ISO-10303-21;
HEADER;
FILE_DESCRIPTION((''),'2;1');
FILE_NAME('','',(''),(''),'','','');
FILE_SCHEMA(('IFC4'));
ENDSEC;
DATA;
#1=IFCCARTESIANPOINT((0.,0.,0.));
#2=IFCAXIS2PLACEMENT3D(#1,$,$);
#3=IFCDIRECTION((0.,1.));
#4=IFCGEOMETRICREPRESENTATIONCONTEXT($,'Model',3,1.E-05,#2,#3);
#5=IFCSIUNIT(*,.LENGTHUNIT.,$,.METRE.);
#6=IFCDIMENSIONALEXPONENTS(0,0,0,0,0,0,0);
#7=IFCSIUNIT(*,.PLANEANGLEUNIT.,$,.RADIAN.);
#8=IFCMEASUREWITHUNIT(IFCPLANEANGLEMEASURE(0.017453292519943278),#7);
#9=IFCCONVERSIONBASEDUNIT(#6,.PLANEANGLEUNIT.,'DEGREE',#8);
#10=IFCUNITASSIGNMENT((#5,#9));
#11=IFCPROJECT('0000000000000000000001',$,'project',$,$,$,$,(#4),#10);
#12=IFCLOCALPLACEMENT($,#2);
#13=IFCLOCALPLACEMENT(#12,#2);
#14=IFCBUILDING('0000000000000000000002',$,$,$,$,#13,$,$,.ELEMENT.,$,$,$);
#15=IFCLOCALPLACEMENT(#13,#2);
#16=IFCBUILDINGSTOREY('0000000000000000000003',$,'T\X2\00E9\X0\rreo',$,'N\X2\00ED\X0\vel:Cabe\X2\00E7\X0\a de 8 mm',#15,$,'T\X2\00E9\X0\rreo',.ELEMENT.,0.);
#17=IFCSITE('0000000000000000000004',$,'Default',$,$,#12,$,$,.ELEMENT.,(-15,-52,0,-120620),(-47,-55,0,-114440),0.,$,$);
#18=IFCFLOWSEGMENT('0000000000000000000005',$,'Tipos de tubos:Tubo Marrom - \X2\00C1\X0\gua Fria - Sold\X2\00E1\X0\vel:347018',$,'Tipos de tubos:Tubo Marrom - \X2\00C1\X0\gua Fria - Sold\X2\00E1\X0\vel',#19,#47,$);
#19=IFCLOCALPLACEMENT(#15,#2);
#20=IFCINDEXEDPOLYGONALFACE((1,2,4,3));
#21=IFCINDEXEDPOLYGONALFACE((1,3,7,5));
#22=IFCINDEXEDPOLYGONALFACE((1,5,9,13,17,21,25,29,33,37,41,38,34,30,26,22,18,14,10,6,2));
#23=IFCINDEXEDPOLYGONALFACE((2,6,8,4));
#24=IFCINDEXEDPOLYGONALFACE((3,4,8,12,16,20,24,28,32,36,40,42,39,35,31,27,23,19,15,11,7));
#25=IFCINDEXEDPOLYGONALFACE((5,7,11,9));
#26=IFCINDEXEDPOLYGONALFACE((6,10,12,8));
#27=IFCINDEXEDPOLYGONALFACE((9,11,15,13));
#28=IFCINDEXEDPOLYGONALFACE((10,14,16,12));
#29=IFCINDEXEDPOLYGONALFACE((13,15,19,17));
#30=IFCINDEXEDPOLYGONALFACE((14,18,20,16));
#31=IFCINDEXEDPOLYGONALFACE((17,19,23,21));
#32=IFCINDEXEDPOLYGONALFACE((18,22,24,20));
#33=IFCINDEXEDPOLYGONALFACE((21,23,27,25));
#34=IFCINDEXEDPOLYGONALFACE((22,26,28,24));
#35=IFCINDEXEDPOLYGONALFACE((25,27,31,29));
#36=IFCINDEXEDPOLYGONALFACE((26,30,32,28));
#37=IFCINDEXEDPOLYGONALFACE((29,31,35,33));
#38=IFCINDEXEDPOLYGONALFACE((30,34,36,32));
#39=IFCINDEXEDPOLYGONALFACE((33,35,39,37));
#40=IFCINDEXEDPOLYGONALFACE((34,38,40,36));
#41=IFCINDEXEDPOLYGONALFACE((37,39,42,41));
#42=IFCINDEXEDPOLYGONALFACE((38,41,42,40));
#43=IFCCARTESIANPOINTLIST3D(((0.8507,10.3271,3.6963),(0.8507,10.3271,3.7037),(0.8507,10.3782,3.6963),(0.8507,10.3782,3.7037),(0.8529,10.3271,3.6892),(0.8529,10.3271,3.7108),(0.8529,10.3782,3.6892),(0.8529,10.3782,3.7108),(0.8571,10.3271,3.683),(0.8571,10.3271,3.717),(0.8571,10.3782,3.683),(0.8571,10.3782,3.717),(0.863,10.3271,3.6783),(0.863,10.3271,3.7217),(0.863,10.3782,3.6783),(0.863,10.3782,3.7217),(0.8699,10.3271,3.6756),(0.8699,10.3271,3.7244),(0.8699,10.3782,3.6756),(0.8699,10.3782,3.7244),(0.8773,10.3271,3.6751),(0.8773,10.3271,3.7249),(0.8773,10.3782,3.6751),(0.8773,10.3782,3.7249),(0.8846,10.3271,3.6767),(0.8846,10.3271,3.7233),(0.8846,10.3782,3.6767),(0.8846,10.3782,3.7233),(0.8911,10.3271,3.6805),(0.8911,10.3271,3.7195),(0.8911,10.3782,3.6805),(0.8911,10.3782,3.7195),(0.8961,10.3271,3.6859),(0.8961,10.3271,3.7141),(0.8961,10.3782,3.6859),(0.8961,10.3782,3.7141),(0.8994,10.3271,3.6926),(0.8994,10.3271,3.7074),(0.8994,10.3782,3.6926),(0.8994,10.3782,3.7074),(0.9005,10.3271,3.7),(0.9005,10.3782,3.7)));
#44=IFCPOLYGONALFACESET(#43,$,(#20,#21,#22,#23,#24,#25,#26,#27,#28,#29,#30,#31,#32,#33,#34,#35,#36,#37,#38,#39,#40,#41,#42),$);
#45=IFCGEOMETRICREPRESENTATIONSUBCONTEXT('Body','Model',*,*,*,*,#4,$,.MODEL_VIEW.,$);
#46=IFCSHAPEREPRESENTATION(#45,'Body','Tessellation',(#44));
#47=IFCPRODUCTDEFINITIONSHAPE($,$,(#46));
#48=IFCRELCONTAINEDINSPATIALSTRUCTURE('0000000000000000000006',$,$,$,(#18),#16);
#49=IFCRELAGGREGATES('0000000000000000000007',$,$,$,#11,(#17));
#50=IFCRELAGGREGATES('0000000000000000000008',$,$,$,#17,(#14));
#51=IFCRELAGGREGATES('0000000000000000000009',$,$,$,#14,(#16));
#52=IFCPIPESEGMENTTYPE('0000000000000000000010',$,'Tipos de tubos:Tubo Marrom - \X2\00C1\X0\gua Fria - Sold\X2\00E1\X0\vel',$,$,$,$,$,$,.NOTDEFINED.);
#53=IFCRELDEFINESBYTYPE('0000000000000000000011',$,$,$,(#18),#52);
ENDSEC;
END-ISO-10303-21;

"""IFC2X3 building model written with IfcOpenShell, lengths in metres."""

from ifc_helpers import new_model, entity, si_unit, converted_unit, direction, frame, origin, origin_2d_with_axis, place, context, subcontext, project, spatial, circle, extrude, type_object, element, save


model = new_model("IFC2X3")

# Units and contexts
model_context = context("Model", 3, precision=1e-05, world=origin(), true_north=direction((0.0, 1.0)))
body_context = subcontext(model_context, "Body", "Model", "MODEL_VIEW")
ifc_project = project(units=[si_unit("LENGTHUNIT", "METRE"), converted_unit("PLANEANGLEUNIT", "DEGREE", entity("IfcPlaneAngleMeasure", 0.017453292519943278), si_unit("PLANEANGLEUNIT", "RADIAN"), dimensions=[0, 0, 0, 0, 0, 0, 0])], contexts=[model_context])

# Site, building, storey
site_placement = place(None, origin())
site = spatial("IfcSite", under=ifc_project, at=site_placement, Name="Default", CompositionType="ELEMENT", RefLatitude=(-15, -52, 0, -120620), RefLongitude=(-47, -55, 0, -114440), RefElevation=0.0)
building_placement = place(site_placement, origin())
building = spatial("IfcBuilding", under=site, at=building_placement, CompositionType="ELEMENT")
storey_placement = place(building_placement, origin())
storey = spatial("IfcBuildingStorey", under=building, at=storey_placement, Name="Térreo", ObjectType="Nível:Cabeça de 8 mm", LongName="Térreo", CompositionType="ELEMENT", Elevation=0.0)

# Flow segment
pipe_segment_type = type_object("IfcPipeSegmentType", Name="Tipos de tubos:Tubo Marrom - Água Fria - Soldável", PredefinedType="NOTDEFINED")
flow_segment_1_placement = place(storey_placement, origin())
element("IfcFlowSegment", 1, at=flow_segment_1_placement, inside=storey, type_object=pipe_segment_type, Name="Tipos de tubos:Tubo Marrom - Água Fria - Soldável:347018", ObjectType="Tipos de tubos:Tubo Marrom - Água Fria - Soldável", context=body_context, shape_type="SweptSolid", body=[
    extrude(circle(Radius=0.025, at=origin_2d_with_axis()), frame((0.8755, 10.3271, 3.7), z_axis=(0.0, 1.0, 0.0), x_axis=(1.0, 0.0, 0.0)), (0.0, 0.0, 1.0), 0.0511),
])

save(model, "model.ifc")
